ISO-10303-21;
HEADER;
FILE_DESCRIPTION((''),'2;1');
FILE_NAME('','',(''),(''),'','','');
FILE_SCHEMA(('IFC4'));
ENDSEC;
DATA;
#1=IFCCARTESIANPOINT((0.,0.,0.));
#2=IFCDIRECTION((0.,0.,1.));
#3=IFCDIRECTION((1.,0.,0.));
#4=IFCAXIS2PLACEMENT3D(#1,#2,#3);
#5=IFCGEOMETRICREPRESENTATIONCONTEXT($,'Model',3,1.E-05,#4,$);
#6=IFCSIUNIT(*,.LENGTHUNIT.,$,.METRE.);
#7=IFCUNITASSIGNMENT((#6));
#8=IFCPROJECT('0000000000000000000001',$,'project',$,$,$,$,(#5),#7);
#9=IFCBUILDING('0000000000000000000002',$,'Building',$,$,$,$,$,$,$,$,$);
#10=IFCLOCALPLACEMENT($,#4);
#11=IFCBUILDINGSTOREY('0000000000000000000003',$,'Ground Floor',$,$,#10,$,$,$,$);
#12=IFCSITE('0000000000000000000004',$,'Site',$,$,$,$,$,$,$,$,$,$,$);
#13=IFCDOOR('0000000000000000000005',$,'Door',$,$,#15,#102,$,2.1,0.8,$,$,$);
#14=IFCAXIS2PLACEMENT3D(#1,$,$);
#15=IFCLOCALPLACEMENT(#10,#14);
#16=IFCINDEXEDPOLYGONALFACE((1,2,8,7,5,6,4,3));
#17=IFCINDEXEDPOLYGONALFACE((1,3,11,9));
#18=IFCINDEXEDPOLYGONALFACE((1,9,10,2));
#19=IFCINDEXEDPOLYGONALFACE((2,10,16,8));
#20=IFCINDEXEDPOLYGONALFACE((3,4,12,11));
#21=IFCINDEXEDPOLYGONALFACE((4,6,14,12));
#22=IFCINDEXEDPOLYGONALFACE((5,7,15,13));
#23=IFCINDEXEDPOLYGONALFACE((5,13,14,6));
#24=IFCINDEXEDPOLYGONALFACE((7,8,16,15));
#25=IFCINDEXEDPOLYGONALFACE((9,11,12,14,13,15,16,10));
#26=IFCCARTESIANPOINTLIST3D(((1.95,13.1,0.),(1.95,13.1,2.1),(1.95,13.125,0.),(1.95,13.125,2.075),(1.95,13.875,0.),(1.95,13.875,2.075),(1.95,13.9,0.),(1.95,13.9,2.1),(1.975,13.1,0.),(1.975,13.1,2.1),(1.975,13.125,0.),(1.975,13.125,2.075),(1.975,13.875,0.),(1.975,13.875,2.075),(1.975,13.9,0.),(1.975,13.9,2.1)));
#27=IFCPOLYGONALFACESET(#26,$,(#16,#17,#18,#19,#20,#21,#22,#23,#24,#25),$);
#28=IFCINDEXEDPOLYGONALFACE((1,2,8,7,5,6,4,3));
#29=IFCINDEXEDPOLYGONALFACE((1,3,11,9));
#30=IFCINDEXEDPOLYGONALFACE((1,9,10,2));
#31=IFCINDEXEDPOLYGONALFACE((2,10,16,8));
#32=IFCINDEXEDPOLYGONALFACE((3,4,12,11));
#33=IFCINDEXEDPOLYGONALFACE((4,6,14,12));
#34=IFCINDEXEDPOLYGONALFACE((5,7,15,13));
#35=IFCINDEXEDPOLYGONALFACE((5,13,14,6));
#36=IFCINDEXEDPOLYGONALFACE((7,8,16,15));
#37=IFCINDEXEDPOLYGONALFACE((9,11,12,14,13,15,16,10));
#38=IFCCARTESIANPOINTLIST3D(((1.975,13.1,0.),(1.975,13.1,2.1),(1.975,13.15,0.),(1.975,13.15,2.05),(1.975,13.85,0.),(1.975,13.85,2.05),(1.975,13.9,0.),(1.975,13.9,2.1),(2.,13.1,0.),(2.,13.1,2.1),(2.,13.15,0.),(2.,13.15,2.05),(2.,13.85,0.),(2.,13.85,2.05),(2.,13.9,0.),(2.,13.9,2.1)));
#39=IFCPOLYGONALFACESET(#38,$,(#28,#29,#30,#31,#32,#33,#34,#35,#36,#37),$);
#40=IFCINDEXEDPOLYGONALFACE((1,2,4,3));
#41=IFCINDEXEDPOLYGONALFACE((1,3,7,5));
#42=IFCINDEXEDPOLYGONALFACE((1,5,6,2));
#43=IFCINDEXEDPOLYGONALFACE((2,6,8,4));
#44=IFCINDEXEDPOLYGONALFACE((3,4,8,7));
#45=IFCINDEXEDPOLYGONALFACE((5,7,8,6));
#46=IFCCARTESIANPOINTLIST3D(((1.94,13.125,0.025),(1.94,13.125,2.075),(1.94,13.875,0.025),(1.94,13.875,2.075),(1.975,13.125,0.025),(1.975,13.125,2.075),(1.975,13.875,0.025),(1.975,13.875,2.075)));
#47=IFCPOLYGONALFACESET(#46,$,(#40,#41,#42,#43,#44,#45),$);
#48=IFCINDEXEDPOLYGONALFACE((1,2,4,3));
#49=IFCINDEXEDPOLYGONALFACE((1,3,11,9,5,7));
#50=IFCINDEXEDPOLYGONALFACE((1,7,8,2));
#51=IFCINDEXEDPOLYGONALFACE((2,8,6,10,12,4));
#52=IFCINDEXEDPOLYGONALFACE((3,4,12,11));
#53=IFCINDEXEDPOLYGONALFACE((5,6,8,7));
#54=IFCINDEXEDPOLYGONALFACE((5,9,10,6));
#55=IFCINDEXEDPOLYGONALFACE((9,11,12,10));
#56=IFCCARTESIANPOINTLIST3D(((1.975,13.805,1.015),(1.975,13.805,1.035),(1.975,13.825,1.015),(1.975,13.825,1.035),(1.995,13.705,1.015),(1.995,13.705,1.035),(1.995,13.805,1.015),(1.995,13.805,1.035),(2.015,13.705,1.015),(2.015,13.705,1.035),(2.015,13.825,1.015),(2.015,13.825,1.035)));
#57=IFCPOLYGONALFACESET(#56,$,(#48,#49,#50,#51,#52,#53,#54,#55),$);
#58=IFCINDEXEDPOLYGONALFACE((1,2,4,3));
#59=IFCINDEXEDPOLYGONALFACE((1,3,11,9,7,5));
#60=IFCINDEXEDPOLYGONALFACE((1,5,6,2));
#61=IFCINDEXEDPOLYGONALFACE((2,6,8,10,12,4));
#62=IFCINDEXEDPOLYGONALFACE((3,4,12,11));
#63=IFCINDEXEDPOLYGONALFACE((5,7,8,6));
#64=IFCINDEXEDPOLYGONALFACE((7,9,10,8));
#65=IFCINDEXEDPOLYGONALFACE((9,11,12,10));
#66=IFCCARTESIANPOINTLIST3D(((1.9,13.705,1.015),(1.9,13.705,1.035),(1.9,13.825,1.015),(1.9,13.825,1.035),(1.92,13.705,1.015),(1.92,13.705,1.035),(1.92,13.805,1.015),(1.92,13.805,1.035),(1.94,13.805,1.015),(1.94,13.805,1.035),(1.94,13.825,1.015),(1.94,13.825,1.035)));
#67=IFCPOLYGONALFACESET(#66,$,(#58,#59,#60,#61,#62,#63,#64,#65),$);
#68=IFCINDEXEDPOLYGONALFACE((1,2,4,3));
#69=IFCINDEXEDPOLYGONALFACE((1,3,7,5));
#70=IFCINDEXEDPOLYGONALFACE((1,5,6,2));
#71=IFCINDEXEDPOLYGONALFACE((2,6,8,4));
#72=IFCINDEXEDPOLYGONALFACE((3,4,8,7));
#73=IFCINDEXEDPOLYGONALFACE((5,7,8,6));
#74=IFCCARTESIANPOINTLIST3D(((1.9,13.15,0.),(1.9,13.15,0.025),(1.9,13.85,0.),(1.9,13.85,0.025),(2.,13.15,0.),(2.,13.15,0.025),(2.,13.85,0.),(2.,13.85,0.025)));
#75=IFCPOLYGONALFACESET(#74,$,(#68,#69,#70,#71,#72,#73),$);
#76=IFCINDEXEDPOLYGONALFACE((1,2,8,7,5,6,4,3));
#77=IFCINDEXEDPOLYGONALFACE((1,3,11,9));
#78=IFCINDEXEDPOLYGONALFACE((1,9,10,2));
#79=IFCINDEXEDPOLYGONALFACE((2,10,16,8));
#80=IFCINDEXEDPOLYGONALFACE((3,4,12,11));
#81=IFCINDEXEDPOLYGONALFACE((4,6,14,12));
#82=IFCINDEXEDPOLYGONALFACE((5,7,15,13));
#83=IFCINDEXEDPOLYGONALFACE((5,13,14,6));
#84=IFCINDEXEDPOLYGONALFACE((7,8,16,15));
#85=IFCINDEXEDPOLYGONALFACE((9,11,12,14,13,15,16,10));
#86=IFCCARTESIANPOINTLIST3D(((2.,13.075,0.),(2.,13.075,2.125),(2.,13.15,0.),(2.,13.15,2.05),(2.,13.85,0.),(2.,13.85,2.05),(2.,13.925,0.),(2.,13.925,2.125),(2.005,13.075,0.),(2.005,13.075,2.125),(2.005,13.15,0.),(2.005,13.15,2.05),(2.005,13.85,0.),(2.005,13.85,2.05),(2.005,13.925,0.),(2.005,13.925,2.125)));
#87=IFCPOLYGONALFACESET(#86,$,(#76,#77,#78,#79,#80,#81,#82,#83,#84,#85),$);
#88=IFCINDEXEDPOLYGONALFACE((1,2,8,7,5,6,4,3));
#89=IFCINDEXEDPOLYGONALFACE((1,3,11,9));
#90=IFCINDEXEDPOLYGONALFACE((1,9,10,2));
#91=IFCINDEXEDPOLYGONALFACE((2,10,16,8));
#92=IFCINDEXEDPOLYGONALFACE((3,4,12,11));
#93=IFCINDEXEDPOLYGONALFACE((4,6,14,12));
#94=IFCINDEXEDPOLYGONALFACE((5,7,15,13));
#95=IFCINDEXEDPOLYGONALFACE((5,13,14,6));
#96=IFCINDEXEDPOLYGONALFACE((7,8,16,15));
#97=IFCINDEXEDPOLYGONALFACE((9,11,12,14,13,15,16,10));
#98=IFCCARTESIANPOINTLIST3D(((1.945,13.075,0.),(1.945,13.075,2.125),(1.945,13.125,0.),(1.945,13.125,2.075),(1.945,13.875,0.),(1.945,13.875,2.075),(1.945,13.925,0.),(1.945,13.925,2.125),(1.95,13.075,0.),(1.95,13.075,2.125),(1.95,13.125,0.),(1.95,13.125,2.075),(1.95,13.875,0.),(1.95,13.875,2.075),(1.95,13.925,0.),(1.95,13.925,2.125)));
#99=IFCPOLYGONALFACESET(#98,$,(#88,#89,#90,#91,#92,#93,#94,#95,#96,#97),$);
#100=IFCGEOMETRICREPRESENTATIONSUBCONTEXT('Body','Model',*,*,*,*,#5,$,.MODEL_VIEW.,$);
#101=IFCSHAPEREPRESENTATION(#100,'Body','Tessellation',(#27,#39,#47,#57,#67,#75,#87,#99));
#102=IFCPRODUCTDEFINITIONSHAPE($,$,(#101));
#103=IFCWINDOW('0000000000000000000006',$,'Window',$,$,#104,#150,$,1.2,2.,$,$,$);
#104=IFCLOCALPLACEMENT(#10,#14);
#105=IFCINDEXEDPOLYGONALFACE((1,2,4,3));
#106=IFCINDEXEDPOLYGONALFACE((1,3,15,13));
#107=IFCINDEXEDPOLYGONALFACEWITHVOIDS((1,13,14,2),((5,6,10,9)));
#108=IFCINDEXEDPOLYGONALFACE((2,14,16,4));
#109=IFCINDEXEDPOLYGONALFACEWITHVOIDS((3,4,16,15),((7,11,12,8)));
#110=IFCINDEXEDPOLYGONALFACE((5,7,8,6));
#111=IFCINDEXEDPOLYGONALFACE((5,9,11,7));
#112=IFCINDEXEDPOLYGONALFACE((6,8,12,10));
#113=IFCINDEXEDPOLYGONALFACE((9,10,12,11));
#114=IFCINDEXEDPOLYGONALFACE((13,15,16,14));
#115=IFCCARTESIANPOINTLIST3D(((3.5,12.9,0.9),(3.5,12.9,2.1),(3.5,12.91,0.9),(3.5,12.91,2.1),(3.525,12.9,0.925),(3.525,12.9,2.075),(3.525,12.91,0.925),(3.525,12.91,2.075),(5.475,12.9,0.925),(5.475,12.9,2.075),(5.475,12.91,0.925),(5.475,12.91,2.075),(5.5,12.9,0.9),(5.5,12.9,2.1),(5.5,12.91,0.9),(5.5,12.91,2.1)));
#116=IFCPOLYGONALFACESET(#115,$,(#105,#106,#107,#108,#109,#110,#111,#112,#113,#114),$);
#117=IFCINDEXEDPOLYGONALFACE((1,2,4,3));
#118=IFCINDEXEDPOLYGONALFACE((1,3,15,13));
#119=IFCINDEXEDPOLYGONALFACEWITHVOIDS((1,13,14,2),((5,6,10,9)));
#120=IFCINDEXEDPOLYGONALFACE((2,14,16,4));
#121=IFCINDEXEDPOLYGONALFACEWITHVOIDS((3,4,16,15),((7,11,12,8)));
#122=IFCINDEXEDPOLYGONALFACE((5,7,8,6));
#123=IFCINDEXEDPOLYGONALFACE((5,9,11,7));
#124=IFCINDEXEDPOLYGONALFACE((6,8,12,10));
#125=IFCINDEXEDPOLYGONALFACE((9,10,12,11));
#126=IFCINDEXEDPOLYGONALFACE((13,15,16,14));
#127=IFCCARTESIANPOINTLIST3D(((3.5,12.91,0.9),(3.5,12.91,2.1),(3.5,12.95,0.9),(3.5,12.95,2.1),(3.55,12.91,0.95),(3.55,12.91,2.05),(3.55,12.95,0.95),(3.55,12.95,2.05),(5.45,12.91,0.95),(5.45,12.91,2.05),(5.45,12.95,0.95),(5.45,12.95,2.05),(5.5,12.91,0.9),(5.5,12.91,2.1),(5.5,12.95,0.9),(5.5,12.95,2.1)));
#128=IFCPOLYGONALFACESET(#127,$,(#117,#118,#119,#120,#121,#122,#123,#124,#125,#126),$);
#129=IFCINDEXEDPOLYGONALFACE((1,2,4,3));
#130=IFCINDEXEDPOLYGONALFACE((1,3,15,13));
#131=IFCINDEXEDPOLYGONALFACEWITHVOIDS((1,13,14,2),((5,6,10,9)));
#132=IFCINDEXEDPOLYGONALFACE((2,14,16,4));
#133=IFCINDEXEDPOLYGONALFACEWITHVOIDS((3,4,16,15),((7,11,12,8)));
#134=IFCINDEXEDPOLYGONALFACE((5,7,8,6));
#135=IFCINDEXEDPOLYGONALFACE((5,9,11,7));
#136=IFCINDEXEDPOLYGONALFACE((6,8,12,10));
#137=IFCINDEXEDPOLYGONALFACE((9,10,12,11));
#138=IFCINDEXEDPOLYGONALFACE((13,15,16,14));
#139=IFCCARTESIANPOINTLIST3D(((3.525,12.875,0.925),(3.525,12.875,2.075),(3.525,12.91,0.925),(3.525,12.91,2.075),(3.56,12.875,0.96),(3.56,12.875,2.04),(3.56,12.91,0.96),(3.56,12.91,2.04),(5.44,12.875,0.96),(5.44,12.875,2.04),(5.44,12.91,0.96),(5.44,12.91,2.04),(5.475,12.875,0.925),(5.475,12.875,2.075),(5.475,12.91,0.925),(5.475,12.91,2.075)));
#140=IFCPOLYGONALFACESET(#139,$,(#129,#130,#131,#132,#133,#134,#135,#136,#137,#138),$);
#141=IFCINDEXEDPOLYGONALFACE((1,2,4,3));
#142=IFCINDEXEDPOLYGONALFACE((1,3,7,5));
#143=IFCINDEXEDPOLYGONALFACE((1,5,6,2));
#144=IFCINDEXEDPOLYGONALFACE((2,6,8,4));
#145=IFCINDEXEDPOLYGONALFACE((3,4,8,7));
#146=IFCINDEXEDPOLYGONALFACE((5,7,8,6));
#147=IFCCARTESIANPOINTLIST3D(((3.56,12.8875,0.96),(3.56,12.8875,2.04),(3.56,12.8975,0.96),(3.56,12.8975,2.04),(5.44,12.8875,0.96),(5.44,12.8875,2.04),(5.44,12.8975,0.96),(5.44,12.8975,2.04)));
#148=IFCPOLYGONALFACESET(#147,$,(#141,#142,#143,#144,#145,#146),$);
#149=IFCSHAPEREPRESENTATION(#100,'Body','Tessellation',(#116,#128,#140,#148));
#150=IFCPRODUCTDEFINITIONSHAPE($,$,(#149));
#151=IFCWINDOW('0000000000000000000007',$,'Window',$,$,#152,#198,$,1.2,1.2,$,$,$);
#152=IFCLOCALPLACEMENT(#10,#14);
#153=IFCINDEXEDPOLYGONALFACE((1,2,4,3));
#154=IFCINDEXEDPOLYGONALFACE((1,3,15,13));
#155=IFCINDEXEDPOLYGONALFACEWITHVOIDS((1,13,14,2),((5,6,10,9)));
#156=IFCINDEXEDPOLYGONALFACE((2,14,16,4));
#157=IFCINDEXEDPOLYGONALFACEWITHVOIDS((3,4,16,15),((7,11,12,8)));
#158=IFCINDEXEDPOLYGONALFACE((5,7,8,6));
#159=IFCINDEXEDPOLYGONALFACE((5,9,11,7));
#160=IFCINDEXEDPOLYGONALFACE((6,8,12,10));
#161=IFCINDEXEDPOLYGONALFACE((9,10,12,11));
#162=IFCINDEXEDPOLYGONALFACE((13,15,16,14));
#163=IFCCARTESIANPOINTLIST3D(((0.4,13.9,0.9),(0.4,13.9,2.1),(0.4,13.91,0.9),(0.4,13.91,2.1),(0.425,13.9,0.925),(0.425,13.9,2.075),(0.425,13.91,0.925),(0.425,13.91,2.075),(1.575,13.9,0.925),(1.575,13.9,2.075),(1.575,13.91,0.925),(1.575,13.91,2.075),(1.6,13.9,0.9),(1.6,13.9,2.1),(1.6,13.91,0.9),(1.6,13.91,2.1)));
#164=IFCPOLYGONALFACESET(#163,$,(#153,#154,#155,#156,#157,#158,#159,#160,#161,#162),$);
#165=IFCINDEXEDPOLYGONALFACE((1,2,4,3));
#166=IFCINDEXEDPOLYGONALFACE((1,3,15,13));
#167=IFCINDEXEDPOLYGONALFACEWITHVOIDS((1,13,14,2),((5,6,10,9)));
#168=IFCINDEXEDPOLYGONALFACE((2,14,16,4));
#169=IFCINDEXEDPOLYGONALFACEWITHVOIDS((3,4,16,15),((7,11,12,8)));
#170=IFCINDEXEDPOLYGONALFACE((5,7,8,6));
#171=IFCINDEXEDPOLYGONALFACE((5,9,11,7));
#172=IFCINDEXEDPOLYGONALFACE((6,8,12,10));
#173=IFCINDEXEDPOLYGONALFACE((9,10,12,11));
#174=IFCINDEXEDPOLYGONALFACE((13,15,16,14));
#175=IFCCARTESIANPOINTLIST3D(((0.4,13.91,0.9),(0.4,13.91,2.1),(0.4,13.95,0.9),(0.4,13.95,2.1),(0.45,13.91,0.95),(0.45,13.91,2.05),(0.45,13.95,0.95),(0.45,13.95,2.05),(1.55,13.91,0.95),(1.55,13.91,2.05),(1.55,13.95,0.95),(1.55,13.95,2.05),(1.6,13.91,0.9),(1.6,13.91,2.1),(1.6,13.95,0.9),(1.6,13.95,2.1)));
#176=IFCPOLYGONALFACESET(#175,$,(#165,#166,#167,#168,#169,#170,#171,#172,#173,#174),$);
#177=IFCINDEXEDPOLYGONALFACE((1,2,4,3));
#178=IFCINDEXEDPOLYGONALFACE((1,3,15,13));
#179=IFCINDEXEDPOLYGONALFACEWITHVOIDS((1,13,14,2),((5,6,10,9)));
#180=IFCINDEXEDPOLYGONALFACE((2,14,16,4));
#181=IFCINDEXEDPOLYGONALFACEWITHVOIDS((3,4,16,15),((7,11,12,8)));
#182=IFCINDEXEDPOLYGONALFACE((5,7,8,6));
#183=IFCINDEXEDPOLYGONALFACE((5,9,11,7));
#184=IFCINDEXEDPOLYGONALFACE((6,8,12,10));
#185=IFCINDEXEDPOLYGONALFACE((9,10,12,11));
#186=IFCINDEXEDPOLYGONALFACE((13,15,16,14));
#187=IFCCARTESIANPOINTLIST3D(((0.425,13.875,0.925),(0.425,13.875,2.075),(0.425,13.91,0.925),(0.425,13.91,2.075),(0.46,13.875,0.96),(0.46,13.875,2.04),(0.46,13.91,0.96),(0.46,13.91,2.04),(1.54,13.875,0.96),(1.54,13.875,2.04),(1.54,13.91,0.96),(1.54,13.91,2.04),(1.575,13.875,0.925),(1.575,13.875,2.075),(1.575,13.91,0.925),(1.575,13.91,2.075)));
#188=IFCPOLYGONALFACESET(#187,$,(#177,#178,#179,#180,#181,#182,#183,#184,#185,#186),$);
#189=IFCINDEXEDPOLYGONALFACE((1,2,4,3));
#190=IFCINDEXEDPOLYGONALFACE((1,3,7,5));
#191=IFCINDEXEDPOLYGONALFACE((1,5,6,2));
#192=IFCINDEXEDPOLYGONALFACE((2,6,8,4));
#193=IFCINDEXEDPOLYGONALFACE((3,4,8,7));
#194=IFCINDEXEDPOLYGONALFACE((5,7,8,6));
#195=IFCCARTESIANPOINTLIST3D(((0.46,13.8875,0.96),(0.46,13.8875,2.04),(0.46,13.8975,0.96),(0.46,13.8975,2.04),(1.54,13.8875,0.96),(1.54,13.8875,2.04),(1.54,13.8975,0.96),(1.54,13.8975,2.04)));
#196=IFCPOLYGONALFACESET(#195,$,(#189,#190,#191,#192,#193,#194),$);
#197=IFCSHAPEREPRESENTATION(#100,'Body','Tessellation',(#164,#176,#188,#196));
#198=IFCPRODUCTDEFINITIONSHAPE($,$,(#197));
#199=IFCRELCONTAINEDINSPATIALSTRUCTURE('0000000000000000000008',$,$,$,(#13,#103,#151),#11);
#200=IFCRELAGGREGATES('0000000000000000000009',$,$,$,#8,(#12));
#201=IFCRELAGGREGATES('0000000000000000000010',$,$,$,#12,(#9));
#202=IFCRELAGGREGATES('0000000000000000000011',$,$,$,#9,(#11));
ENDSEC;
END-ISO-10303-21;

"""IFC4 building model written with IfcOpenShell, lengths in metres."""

from ifc_helpers import new_model, si_unit, frame, origin_with_axes, place, context, subcontext, project, spatial, line, indexed_curve, outline, extrude, element, save


model = new_model("IFC4")

# Units and contexts
model_context = context("Model", 3, precision=1e-05, world=origin_with_axes())
body_context = subcontext(model_context, "Body", "Model", "MODEL_VIEW")
ifc_project = project(units=[si_unit("LENGTHUNIT", "METRE")], contexts=[model_context])

# Site, building, storey
site = spatial("IfcSite", under=ifc_project, Name="Site")
building = spatial("IfcBuilding", under=site, Name="Building")
storey_placement = place(None, origin_with_axes())
storey = spatial("IfcBuildingStorey", under=building, at=storey_placement, Name="Ground Floor")

# Door
door_1_placement = place(storey_placement, frame((2.0, 13.1, 0.0), z_axis=(0.0, 0.0, 1.0), x_axis=(0.0, 1.0, 0.0)))
element("IfcDoor", 1, at=door_1_placement, inside=storey, Name="Door", OverallHeight=2.1, OverallWidth=0.8, context=body_context, shape_type="SweptSolid", body=[
    extrude(outline(indexed_curve([(0.0, 0.0), (0.0, 2.1), (0.8, 2.1), (0.8, 0.0), (0.775, 0.0), (0.775, 2.075), (0.025, 2.075), (0.025, 0.0)], segments=[line(1, 2, 3, 4, 5, 6, 7, 8, 1)])), frame((0.0, 0.025, 0.0), z_axis=(0.0, -1.0, 0.0), x_axis=(1.0, 0.0, 0.0)), (0.0, 0.0, -1.0), 0.025),
    extrude(outline(indexed_curve([(0.0, 0.0), (0.0, 2.1), (0.8, 2.1), (0.8, 0.0), (0.75, 0.0), (0.75, 2.05), (0.05, 2.05), (0.05, 0.0)], segments=[line(1, 2, 3, 4, 5, 6, 7, 8, 1)])), frame((0.0, 0.0, 0.0), z_axis=(0.0, -1.0, 0.0), x_axis=(1.0, 0.0, 0.0)), (0.0, 0.0, -1.0), 0.025),
    extrude(outline(indexed_curve([(0.0, 0.0), (0.75, 0.0), (0.75, 0.035), (0.0, 0.035)], segments=[line(1, 2, 3, 4, 1)])), frame((0.025, 0.025, 0.025), z_axis=(0.0, 0.0, 1.0), x_axis=(1.0, 0.0, 0.0)), (0.0, 0.0, 1.0), 2.05),
    extrude(outline(indexed_curve([(0.0, 0.0), (0.0, -0.04), (-0.12, -0.04), (-0.12, -0.02), (-0.02, -0.02), (-0.02, 0.0)], segments=[line(1, 2, 3, 4, 5, 6, 1)])), frame((0.725, 0.025, 1.015), z_axis=(0.0, 0.0, 1.0), x_axis=(1.0, 0.0, 0.0)), (0.0, 0.0, 1.0), 0.02),
    extrude(outline(indexed_curve([(0.0, 0.0), (0.0, 0.04), (-0.12, 0.04), (-0.12, 0.02), (-0.02, 0.02), (-0.02, 0.0)], segments=[line(1, 2, 3, 4, 5, 6, 1)])), frame((0.725, 0.06, 1.015), z_axis=(0.0, 0.0, 1.0), x_axis=(1.0, 0.0, 0.0)), (0.0, 0.0, 1.0), 0.02),
    extrude(outline(indexed_curve([(0.0, 0.0), (0.7, 0.0), (0.7, 0.1), (0.0, 0.1)], segments=[line(1, 2, 3, 4, 1)])), frame((0.05, 0.0, 0.0), z_axis=(0.0, 0.0, 1.0), x_axis=(1.0, 0.0, 0.0)), (0.0, 0.0, 1.0), 0.025),
    extrude(outline(indexed_curve([(0.0, 0.0), (0.0, 2.125), (0.85, 2.125), (0.85, 0.0), (0.775, 0.0), (0.775, 2.05), (0.075, 2.05), (0.075, 0.0)], segments=[line(1, 2, 3, 4, 5, 6, 7, 8, 1)])), frame((-0.025, -0.005, 0.0), z_axis=(0.0, -1.0, 0.0), x_axis=(1.0, 0.0, 0.0)), (0.0, 0.0, -1.0), 0.005),
    extrude(outline(indexed_curve([(0.0, 0.0), (0.0, 2.125), (0.85, 2.125), (0.85, 0.0), (0.8, 0.0), (0.8, 2.075), (0.05, 2.075), (0.05, 0.0)], segments=[line(1, 2, 3, 4, 5, 6, 7, 8, 1)])), frame((-0.025, 0.05, 0.0), z_axis=(0.0, -1.0, 0.0), x_axis=(1.0, 0.0, 0.0)), (0.0, 0.0, -1.0), 0.005),
])

# Windows
window_1_placement = place(storey_placement, frame((5.5, 13.0, 0.9), z_axis=(0.0, 0.0, 1.0), x_axis=(-1.0, 0.0, 0.0)))
element("IfcWindow", 2, at=window_1_placement, inside=storey, Name="Window", OverallHeight=1.2, OverallWidth=2.0, context=body_context, shape_type="SweptSolid", body=[
    extrude(outline(indexed_curve([(0.0, 0.0), (2.0, 0.0), (2.0, 1.2), (0.0, 1.2)], segments=[line(1, 2, 3, 4, 1)]), holes=[indexed_curve([(0.025, 0.025), (1.975, 0.025), (1.975, 1.175), (0.025, 1.175)], segments=[line(1, 2, 3, 4, 1)])]), frame((0.0, 0.09, 0.0), z_axis=(0.0, -1.0, 0.0), x_axis=(1.0, 0.0, 0.0)), (0.0, 0.0, -1.0), 0.01),
    extrude(outline(indexed_curve([(0.0, 0.0), (2.0, 0.0), (2.0, 1.2), (0.0, 1.2)], segments=[line(1, 2, 3, 4, 1)]), holes=[indexed_curve([(0.05, 0.05), (1.95, 0.05), (1.95, 1.15), (0.05, 1.15)], segments=[line(1, 2, 3, 4, 1)])]), frame((0.0, 0.05, 0.0), z_axis=(0.0, -1.0, 0.0), x_axis=(1.0, 0.0, 0.0)), (0.0, 0.0, -1.0), 0.04),
    extrude(outline(indexed_curve([(0.0, 0.0), (1.95, 0.0), (1.95, 1.15), (0.0, 1.15)], segments=[line(1, 2, 3, 4, 1)]), holes=[indexed_curve([(0.035, 0.035), (1.915, 0.035), (1.915, 1.115), (0.035, 1.115)], segments=[line(1, 2, 3, 4, 1)])]), frame((0.025, 0.09, 0.025), z_axis=(0.0, -1.0, 0.0), x_axis=(1.0, 0.0, 0.0)), (0.0, 0.0, -1.0), 0.035),
    extrude(outline(indexed_curve([(0.035, 0.035), (1.915, 0.035), (1.915, 1.115), (0.035, 1.115)], segments=[line(1, 2, 3, 4, 1)])), frame((0.025, 0.1025, 0.025), z_axis=(0.0, -1.0, 0.0), x_axis=(1.0, 0.0, 0.0)), (0.0, 0.0, -1.0), 0.01),
])
for number, where, z_axis, x_axis, name in (
    (3, (1.6, 14.0, 0.9), (0.0, 0.0, 1.0), (-1.0, 0.0, 0.0), "Window"),
):
    element("IfcWindow", number, at=place(storey_placement, frame(where, z_axis=z_axis, x_axis=x_axis)), inside=storey, Name=name, OverallHeight=1.2, OverallWidth=1.2, context=body_context, shape_type="SweptSolid", body=[
        extrude(outline(indexed_curve([(0.0, 0.0), (1.2, 0.0), (1.2, 1.2), (0.0, 1.2)], segments=[line(1, 2, 3, 4, 1)]), holes=[indexed_curve([(0.025, 0.025), (1.175, 0.025), (1.175, 1.175), (0.025, 1.175)], segments=[line(1, 2, 3, 4, 1)])]), frame((0.0, 0.09, 0.0), z_axis=(0.0, -1.0, 0.0), x_axis=(1.0, 0.0, 0.0)), (0.0, 0.0, -1.0), 0.01),
        extrude(outline(indexed_curve([(0.0, 0.0), (1.2, 0.0), (1.2, 1.2), (0.0, 1.2)], segments=[line(1, 2, 3, 4, 1)]), holes=[indexed_curve([(0.05, 0.05), (1.15, 0.05), (1.15, 1.15), (0.05, 1.15)], segments=[line(1, 2, 3, 4, 1)])]), frame((0.0, 0.05, 0.0), z_axis=(0.0, -1.0, 0.0), x_axis=(1.0, 0.0, 0.0)), (0.0, 0.0, -1.0), 0.04),
        extrude(outline(indexed_curve([(0.0, 0.0), (1.15, 0.0), (1.15, 1.15), (0.0, 1.15)], segments=[line(1, 2, 3, 4, 1)]), holes=[indexed_curve([(0.035, 0.035), (1.115, 0.035), (1.115, 1.115), (0.035, 1.115)], segments=[line(1, 2, 3, 4, 1)])]), frame((0.025, 0.09, 0.025), z_axis=(0.0, -1.0, 0.0), x_axis=(1.0, 0.0, 0.0)), (0.0, 0.0, -1.0), 0.035),
        extrude(outline(indexed_curve([(0.035, 0.035), (1.115, 0.035), (1.115, 1.115), (0.035, 1.115)], segments=[line(1, 2, 3, 4, 1)])), frame((0.025, 0.1025, 0.025), z_axis=(0.0, -1.0, 0.0), x_axis=(1.0, 0.0, 0.0)), (0.0, 0.0, -1.0), 0.01),
    ])

save(model, "model.ifc")
